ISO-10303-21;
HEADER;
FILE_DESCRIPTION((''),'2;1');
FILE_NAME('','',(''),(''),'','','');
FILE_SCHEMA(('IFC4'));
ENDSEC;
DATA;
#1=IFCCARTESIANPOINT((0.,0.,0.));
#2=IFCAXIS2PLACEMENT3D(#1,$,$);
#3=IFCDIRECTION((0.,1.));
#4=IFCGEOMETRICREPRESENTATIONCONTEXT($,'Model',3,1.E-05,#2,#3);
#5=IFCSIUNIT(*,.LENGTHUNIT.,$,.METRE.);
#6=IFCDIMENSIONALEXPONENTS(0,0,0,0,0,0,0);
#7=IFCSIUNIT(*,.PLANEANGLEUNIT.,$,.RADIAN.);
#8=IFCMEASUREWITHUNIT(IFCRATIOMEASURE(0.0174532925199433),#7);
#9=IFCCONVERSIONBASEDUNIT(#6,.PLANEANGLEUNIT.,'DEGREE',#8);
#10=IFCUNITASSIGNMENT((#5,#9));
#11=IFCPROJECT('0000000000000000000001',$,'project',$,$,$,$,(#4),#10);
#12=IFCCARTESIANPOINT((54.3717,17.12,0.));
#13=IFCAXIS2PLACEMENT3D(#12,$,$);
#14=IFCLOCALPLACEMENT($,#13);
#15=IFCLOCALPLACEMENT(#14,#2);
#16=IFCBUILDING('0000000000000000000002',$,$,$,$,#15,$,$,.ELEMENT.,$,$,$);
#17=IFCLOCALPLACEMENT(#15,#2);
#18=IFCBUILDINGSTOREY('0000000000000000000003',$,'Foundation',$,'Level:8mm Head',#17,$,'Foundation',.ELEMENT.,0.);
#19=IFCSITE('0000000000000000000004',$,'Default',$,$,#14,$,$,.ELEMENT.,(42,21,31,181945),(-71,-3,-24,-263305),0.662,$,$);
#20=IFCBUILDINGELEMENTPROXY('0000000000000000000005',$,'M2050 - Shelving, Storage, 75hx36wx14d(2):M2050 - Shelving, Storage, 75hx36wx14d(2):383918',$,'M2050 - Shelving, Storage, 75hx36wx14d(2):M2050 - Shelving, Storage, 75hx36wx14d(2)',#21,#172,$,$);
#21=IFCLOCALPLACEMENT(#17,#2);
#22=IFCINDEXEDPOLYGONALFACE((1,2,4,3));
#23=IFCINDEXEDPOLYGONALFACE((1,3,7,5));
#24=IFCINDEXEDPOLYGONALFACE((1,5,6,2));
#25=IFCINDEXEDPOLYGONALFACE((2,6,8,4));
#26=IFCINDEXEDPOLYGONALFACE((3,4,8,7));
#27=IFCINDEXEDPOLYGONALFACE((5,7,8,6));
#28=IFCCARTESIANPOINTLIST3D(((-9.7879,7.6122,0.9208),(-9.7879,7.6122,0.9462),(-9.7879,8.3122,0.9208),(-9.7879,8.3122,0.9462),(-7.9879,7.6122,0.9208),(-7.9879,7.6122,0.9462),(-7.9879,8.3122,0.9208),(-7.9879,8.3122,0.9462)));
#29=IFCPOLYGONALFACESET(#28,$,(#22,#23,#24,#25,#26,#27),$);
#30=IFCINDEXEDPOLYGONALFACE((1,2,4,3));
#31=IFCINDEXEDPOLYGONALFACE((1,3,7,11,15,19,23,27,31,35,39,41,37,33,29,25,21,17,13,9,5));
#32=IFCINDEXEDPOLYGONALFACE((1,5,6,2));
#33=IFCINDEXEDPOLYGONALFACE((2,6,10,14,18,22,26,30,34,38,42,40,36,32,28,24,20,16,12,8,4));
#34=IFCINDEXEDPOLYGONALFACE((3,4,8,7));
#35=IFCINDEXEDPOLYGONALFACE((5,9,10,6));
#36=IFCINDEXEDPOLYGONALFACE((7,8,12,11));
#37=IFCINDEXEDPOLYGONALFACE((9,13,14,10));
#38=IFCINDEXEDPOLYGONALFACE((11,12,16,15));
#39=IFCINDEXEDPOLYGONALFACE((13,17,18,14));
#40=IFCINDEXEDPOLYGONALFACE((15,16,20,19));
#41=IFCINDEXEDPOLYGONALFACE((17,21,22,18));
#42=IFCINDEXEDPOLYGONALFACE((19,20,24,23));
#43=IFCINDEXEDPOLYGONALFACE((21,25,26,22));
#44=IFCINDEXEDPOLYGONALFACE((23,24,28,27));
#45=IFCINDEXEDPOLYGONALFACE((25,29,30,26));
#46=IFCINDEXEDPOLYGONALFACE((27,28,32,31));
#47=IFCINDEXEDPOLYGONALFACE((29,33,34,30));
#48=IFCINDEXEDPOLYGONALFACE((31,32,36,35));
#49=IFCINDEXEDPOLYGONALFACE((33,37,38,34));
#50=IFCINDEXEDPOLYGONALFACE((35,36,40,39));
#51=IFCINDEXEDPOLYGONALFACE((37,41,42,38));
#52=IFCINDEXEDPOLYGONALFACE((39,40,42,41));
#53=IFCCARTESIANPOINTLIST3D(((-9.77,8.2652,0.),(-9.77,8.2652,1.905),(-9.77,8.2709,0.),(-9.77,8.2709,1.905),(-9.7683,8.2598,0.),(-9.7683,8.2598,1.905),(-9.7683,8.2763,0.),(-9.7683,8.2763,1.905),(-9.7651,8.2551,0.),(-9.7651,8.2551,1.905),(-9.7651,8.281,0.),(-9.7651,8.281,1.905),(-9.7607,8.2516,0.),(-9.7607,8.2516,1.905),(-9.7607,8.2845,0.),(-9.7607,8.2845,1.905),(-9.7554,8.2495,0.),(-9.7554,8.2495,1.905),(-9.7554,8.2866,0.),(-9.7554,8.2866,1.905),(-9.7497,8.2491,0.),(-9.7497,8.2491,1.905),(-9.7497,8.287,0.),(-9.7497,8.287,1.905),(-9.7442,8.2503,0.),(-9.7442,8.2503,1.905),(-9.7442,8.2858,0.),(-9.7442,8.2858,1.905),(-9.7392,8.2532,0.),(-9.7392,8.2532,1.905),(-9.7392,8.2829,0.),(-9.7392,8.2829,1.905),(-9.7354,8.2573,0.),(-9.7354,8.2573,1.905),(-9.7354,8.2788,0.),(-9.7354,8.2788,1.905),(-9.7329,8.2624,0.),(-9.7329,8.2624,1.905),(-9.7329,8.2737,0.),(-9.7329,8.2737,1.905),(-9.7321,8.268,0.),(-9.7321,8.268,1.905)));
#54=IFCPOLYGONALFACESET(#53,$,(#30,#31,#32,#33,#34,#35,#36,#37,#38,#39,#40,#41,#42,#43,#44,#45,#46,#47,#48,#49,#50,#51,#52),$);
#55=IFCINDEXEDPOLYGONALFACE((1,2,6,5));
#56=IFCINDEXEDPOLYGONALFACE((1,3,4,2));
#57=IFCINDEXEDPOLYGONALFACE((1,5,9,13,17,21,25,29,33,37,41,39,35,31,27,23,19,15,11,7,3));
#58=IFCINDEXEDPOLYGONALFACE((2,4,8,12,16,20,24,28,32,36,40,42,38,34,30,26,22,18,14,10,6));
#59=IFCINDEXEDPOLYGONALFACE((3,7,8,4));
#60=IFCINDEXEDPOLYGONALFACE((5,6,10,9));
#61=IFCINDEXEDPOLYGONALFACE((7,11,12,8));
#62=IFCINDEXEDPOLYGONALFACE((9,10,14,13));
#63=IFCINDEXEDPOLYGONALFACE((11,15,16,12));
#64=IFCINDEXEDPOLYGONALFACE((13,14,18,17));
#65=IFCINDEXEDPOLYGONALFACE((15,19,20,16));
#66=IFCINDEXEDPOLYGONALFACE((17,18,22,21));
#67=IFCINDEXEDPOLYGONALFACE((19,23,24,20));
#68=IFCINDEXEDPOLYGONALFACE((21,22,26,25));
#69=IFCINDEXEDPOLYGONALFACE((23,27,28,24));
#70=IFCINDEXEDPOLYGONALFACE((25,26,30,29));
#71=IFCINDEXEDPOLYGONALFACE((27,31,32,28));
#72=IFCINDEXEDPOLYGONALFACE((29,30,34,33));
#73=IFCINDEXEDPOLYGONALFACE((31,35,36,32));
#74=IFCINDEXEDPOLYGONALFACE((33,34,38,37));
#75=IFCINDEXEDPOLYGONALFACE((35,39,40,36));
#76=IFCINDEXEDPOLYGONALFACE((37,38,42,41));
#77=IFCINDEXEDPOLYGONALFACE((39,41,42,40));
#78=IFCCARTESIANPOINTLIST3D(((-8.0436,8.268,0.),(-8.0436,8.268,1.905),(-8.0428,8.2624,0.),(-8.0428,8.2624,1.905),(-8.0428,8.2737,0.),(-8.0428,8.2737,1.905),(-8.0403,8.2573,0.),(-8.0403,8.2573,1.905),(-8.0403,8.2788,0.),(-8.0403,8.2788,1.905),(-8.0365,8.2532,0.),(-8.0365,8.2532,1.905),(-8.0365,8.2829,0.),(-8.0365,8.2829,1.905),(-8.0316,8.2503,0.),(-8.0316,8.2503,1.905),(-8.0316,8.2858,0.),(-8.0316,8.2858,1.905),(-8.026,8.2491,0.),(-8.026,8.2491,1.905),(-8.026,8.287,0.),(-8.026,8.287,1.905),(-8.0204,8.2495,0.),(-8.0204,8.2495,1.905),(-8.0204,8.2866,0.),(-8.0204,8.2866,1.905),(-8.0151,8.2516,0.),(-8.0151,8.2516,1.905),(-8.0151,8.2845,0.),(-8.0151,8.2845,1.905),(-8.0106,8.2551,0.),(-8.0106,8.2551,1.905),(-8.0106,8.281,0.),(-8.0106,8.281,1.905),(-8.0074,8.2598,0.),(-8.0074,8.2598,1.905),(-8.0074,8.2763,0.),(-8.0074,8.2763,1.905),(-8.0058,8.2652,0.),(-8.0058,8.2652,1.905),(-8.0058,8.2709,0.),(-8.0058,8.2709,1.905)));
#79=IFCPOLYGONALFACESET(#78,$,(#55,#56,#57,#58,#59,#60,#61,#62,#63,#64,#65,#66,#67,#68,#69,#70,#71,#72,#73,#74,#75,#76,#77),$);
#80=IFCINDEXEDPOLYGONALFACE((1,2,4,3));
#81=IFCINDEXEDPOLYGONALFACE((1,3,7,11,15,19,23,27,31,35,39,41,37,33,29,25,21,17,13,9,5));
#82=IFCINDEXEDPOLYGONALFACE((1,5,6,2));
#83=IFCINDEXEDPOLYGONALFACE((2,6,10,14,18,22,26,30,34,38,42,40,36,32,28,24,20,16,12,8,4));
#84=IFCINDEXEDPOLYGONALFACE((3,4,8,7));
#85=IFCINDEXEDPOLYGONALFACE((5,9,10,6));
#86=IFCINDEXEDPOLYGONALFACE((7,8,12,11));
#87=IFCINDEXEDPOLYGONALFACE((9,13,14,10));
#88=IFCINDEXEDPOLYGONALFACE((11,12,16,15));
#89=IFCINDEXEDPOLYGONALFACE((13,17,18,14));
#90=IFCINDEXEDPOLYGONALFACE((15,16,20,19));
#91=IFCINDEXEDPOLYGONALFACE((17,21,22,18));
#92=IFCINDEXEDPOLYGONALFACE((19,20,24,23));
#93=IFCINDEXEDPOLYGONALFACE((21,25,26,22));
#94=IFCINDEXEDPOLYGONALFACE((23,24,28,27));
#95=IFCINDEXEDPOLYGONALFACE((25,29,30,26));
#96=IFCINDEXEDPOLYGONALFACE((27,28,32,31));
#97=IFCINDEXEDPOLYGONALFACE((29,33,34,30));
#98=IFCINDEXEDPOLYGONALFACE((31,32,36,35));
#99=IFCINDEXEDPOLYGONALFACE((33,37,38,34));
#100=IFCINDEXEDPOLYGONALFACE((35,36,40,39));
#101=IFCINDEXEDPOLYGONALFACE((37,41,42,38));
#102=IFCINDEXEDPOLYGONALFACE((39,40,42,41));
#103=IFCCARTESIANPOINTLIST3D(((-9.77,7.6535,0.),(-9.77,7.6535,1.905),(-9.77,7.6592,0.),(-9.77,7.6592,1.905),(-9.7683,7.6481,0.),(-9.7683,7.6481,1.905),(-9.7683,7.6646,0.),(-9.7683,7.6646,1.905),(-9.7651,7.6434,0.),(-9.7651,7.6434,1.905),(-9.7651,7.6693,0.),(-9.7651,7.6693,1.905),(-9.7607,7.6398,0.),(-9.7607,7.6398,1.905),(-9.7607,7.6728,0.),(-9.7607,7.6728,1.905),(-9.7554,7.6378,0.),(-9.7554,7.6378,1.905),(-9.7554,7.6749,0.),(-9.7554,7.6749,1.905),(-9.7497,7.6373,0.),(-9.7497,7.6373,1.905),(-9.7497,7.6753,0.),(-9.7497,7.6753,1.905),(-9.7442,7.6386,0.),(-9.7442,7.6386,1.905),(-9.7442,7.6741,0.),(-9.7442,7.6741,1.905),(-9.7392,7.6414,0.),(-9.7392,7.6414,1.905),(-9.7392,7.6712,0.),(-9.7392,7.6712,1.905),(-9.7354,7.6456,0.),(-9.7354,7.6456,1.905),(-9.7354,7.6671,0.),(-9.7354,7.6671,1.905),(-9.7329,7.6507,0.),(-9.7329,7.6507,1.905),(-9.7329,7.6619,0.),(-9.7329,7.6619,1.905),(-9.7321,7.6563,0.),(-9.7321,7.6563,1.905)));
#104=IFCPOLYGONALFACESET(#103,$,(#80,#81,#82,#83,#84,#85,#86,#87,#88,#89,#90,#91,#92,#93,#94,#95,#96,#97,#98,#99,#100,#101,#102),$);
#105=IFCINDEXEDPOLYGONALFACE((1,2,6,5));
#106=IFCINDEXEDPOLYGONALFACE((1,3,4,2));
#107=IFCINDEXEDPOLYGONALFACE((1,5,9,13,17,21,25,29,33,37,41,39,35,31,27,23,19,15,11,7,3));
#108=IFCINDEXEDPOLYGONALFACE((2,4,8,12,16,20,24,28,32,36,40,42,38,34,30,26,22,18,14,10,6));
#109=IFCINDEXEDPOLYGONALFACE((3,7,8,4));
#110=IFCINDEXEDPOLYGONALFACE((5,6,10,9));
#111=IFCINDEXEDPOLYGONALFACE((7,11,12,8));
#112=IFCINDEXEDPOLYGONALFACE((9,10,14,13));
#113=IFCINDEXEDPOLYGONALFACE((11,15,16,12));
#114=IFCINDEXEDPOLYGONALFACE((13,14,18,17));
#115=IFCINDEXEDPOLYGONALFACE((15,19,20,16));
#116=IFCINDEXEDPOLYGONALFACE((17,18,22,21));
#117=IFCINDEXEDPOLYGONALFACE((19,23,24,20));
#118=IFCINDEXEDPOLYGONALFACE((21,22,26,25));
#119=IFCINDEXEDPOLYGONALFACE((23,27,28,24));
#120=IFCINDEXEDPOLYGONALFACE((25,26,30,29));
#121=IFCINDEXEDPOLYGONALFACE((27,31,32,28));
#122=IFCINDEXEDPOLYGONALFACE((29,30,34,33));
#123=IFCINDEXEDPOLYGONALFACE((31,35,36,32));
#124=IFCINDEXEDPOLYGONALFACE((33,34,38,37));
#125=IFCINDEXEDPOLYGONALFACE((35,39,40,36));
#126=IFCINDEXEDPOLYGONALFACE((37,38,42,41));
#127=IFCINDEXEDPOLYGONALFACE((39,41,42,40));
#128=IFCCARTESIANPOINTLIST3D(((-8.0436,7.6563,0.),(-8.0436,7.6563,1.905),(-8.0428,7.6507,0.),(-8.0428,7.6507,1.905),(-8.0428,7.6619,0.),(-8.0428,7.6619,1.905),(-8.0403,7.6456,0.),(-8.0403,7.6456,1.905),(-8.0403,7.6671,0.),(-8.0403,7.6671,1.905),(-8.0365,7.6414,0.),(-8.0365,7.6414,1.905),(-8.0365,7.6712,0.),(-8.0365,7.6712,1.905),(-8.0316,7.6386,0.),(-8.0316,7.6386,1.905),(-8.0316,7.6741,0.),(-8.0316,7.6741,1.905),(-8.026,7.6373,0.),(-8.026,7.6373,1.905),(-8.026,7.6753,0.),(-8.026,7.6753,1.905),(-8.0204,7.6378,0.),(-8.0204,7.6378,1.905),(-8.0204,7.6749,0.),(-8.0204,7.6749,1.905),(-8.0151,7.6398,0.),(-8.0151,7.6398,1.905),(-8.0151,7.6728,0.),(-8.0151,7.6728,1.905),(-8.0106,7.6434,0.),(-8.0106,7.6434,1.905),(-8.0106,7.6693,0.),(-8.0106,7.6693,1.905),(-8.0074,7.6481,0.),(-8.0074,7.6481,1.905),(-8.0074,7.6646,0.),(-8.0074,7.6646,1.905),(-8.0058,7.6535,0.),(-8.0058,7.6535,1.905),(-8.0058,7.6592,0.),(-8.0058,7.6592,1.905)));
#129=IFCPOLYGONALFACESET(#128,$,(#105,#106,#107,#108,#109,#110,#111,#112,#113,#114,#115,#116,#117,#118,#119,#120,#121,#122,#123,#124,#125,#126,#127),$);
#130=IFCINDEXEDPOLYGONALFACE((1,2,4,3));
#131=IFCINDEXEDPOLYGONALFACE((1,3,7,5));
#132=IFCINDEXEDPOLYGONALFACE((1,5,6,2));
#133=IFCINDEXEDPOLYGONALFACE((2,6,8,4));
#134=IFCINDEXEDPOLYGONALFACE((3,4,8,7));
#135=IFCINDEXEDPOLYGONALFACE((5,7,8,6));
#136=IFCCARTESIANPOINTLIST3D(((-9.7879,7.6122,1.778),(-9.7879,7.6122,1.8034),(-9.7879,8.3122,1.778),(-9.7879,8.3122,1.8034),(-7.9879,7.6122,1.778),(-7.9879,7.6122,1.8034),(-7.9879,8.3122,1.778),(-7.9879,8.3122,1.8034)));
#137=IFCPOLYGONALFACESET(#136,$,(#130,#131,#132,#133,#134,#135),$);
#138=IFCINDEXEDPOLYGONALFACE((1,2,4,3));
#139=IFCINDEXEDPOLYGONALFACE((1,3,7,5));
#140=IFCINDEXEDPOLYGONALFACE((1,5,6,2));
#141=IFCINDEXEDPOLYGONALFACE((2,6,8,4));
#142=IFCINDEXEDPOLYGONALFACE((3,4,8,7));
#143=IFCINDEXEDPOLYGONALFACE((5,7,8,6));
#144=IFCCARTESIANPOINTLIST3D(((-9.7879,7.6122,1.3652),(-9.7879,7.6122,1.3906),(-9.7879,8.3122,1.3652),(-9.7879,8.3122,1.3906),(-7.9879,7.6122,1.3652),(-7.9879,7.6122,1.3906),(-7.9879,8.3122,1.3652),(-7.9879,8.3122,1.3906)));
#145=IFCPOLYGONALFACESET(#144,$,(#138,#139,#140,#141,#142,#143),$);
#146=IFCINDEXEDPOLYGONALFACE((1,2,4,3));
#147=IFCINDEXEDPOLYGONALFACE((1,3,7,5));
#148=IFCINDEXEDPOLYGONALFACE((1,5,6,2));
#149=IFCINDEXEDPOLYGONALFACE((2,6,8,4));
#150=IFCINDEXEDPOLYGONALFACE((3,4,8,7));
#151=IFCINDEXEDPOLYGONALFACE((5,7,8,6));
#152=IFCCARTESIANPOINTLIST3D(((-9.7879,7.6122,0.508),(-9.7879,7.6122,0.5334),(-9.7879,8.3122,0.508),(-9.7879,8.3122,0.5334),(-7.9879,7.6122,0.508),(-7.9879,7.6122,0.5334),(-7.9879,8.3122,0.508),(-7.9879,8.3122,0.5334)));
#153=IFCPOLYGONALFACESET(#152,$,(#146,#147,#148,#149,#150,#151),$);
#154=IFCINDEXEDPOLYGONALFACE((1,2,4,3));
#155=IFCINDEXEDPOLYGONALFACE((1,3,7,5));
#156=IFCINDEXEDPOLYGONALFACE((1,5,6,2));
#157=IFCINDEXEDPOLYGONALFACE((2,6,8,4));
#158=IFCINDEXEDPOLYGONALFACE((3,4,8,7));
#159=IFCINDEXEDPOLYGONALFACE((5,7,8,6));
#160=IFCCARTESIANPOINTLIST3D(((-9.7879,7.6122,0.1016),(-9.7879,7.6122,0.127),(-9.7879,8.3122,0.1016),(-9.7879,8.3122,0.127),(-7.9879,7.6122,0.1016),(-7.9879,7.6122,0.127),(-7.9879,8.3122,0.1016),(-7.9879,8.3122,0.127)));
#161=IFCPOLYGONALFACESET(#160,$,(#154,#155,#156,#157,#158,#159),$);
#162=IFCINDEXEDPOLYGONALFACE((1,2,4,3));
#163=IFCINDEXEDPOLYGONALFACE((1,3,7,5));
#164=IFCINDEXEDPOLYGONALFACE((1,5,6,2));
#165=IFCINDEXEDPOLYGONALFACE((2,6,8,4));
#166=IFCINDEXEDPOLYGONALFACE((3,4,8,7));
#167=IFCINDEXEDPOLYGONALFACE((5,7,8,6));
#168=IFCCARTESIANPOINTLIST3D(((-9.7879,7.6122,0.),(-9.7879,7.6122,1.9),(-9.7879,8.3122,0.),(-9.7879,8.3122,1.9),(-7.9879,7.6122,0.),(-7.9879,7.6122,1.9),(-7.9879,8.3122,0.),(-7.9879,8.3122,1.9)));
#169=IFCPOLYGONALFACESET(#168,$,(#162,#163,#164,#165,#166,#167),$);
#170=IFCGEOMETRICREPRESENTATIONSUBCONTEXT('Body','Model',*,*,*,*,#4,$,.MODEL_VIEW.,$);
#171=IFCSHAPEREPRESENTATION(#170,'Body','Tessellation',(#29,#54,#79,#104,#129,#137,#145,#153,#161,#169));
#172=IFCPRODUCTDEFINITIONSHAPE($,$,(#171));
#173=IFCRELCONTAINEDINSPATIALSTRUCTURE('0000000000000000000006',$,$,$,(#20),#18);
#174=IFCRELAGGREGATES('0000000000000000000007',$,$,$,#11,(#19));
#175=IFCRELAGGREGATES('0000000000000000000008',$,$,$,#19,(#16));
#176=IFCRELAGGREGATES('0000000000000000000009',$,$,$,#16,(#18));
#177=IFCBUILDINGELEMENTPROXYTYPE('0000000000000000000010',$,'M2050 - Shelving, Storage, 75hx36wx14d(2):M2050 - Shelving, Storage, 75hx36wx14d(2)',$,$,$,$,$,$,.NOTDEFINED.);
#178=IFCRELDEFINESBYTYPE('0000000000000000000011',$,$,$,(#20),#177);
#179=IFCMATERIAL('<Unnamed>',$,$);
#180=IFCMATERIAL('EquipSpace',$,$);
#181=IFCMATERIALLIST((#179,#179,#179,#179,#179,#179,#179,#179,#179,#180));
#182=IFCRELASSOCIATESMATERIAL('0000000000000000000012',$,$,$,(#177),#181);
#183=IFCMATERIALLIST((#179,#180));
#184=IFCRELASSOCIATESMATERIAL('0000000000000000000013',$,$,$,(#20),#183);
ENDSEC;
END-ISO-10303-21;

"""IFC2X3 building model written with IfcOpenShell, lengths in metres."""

from ifc_helpers import new_model, entity, si_unit, converted_unit, direction, frame, frame_2d, origin, origin_2d_with_axis, place, context, subcontext, project, spatial, rectangle, circle, extrude, source, transform, mapped, material, material_list, type_object, type_shapes, element, save


model = new_model("IFC2X3")

# Units and contexts
model_context = context("Model", 3, precision=1e-05, world=origin(), true_north=direction((0.0, 1.0)))
body_context = subcontext(model_context, "Body", "Model", "MODEL_VIEW")
ifc_project = project(units=[si_unit("LENGTHUNIT", "METRE"), converted_unit("PLANEANGLEUNIT", "DEGREE", entity("IfcRatioMeasure", 0.0174532925199433), si_unit("PLANEANGLEUNIT", "RADIAN"), dimensions=[0, 0, 0, 0, 0, 0, 0])], contexts=[model_context])

# Site, building, storey
site_placement = place(None, frame((54.3717, 17.12, 0.0)))
site = spatial("IfcSite", under=ifc_project, at=site_placement, Name="Default", CompositionType="ELEMENT", RefLatitude=(42, 21, 31, 181945), RefLongitude=(-71, -3, -24, -263305), RefElevation=0.662)
building_placement = place(site_placement, origin())
building = spatial("IfcBuilding", under=site, at=building_placement, CompositionType="ELEMENT")
storey_placement = place(building_placement, origin())
storey = spatial("IfcBuildingStorey", under=building, at=storey_placement, Name="Foundation", ObjectType="Level:8mm Head", LongName="Foundation", CompositionType="ELEMENT", Elevation=0.0)

# Building element proxy
ifc_material_1 = material(Name="<Unnamed>")
ifc_material_2 = material(Name="EquipSpace")
ifc_material_list_1 = material_list([ifc_material_1, ifc_material_1, ifc_material_1, ifc_material_1, ifc_material_1, ifc_material_1, ifc_material_1, ifc_material_1, ifc_material_1, ifc_material_2])
building_element_proxy_type = type_object("IfcBuildingElementProxyType", Name="M2050 - Shelving, Storage, 75hx36wx14d(2):M2050 - Shelving, Storage, 75hx36wx14d(2)", PredefinedType="NOTDEFINED", material=ifc_material_list_1)
shared_shape = source(origin(), body_context, "Body", "SweptSolid", [
    extrude(rectangle(XDim=1.8, YDim=0.7, at=origin_2d_with_axis()), frame((0.0, 0.0, 0.9207), z_axis=(0.0, 0.0, 1.0), x_axis=(-1.0, 0.0, 0.0)), (0.0, 0.0, 1.0), 0.0254),
    extrude(circle(Radius=0.0191, at=origin_2d_with_axis()), frame((0.8633, -0.3059, 0.0), z_axis=(0.0, 0.0, 1.0), x_axis=(-1.0, 0.0, 0.0)), (0.0, 0.0, 1.0), 1.905),
    extrude(circle(Radius=0.0191, at=origin_2d_with_axis()), frame((-0.8633, -0.3059, 0.0)), (0.0, 0.0, 1.0), 1.905),
    extrude(circle(Radius=0.0191, at=origin_2d_with_axis()), frame((0.8633, 0.3059, 0.0), z_axis=(0.0, 0.0, 1.0), x_axis=(-1.0, 0.0, 0.0)), (0.0, 0.0, 1.0), 1.905),
    extrude(circle(Radius=0.0191, at=origin_2d_with_axis()), frame((-0.8633, 0.3059, 0.0)), (0.0, 0.0, 1.0), 1.905),
    extrude(rectangle(XDim=1.8, YDim=0.7, at=origin_2d_with_axis()), frame((0.0, 0.0, 1.778), z_axis=(0.0, 0.0, 1.0), x_axis=(-1.0, 0.0, 0.0)), (0.0, 0.0, 1.0), 0.0254),
    extrude(rectangle(XDim=1.8, YDim=0.7, at=origin_2d_with_axis()), frame((0.0, 0.0, 1.3653), z_axis=(0.0, 0.0, 1.0), x_axis=(-1.0, 0.0, 0.0)), (0.0, 0.0, 1.0), 0.0254),
    extrude(rectangle(XDim=1.8, YDim=0.7, at=origin_2d_with_axis()), frame((0.0, 0.0, 0.508), z_axis=(0.0, 0.0, 1.0), x_axis=(-1.0, 0.0, 0.0)), (0.0, 0.0, 1.0), 0.0254),
    extrude(rectangle(XDim=1.8, YDim=0.7, at=origin_2d_with_axis()), frame((0.0, 0.0, 0.1016), z_axis=(0.0, 0.0, 1.0), x_axis=(-1.0, 0.0, 0.0)), (0.0, 0.0, 1.0), 0.0254),
    extrude(rectangle(XDim=0.7, YDim=1.8, at=frame_2d((0.0, 0.18), x_axis=(1.0, 0.0))), frame((-0.18, 0.0, 0.0), z_axis=(0.0, 0.0, 1.0), x_axis=(0.0, -1.0, 0.0)), (0.0, 0.0, 1.0), 1.9),
])
type_shapes(building_element_proxy_type, [shared_shape])
ifc_material_list_2 = material_list([ifc_material_1, ifc_material_2])
proxy_1_placement = place(storey_placement, frame((-8.8879, 7.9622, 0.0), z_axis=(0.0, 0.0, 1.0), x_axis=(-1.0, 0.0, 0.0)))
element("IfcBuildingElementProxy", 1, at=proxy_1_placement, inside=storey, type_object=building_element_proxy_type, material=ifc_material_list_2, Name="M2050 - Shelving, Storage, 75hx36wx14d(2):M2050 - Shelving, Storage, 75hx36wx14d(2):383918", ObjectType="M2050 - Shelving, Storage, 75hx36wx14d(2):M2050 - Shelving, Storage, 75hx36wx14d(2)", context=body_context, shape_type="MappedRepresentation", body=[
    mapped(shared_shape, transform((0.0, 0.0, 0.0), scale=1.0)),
])

save(model, "model.ifc")
